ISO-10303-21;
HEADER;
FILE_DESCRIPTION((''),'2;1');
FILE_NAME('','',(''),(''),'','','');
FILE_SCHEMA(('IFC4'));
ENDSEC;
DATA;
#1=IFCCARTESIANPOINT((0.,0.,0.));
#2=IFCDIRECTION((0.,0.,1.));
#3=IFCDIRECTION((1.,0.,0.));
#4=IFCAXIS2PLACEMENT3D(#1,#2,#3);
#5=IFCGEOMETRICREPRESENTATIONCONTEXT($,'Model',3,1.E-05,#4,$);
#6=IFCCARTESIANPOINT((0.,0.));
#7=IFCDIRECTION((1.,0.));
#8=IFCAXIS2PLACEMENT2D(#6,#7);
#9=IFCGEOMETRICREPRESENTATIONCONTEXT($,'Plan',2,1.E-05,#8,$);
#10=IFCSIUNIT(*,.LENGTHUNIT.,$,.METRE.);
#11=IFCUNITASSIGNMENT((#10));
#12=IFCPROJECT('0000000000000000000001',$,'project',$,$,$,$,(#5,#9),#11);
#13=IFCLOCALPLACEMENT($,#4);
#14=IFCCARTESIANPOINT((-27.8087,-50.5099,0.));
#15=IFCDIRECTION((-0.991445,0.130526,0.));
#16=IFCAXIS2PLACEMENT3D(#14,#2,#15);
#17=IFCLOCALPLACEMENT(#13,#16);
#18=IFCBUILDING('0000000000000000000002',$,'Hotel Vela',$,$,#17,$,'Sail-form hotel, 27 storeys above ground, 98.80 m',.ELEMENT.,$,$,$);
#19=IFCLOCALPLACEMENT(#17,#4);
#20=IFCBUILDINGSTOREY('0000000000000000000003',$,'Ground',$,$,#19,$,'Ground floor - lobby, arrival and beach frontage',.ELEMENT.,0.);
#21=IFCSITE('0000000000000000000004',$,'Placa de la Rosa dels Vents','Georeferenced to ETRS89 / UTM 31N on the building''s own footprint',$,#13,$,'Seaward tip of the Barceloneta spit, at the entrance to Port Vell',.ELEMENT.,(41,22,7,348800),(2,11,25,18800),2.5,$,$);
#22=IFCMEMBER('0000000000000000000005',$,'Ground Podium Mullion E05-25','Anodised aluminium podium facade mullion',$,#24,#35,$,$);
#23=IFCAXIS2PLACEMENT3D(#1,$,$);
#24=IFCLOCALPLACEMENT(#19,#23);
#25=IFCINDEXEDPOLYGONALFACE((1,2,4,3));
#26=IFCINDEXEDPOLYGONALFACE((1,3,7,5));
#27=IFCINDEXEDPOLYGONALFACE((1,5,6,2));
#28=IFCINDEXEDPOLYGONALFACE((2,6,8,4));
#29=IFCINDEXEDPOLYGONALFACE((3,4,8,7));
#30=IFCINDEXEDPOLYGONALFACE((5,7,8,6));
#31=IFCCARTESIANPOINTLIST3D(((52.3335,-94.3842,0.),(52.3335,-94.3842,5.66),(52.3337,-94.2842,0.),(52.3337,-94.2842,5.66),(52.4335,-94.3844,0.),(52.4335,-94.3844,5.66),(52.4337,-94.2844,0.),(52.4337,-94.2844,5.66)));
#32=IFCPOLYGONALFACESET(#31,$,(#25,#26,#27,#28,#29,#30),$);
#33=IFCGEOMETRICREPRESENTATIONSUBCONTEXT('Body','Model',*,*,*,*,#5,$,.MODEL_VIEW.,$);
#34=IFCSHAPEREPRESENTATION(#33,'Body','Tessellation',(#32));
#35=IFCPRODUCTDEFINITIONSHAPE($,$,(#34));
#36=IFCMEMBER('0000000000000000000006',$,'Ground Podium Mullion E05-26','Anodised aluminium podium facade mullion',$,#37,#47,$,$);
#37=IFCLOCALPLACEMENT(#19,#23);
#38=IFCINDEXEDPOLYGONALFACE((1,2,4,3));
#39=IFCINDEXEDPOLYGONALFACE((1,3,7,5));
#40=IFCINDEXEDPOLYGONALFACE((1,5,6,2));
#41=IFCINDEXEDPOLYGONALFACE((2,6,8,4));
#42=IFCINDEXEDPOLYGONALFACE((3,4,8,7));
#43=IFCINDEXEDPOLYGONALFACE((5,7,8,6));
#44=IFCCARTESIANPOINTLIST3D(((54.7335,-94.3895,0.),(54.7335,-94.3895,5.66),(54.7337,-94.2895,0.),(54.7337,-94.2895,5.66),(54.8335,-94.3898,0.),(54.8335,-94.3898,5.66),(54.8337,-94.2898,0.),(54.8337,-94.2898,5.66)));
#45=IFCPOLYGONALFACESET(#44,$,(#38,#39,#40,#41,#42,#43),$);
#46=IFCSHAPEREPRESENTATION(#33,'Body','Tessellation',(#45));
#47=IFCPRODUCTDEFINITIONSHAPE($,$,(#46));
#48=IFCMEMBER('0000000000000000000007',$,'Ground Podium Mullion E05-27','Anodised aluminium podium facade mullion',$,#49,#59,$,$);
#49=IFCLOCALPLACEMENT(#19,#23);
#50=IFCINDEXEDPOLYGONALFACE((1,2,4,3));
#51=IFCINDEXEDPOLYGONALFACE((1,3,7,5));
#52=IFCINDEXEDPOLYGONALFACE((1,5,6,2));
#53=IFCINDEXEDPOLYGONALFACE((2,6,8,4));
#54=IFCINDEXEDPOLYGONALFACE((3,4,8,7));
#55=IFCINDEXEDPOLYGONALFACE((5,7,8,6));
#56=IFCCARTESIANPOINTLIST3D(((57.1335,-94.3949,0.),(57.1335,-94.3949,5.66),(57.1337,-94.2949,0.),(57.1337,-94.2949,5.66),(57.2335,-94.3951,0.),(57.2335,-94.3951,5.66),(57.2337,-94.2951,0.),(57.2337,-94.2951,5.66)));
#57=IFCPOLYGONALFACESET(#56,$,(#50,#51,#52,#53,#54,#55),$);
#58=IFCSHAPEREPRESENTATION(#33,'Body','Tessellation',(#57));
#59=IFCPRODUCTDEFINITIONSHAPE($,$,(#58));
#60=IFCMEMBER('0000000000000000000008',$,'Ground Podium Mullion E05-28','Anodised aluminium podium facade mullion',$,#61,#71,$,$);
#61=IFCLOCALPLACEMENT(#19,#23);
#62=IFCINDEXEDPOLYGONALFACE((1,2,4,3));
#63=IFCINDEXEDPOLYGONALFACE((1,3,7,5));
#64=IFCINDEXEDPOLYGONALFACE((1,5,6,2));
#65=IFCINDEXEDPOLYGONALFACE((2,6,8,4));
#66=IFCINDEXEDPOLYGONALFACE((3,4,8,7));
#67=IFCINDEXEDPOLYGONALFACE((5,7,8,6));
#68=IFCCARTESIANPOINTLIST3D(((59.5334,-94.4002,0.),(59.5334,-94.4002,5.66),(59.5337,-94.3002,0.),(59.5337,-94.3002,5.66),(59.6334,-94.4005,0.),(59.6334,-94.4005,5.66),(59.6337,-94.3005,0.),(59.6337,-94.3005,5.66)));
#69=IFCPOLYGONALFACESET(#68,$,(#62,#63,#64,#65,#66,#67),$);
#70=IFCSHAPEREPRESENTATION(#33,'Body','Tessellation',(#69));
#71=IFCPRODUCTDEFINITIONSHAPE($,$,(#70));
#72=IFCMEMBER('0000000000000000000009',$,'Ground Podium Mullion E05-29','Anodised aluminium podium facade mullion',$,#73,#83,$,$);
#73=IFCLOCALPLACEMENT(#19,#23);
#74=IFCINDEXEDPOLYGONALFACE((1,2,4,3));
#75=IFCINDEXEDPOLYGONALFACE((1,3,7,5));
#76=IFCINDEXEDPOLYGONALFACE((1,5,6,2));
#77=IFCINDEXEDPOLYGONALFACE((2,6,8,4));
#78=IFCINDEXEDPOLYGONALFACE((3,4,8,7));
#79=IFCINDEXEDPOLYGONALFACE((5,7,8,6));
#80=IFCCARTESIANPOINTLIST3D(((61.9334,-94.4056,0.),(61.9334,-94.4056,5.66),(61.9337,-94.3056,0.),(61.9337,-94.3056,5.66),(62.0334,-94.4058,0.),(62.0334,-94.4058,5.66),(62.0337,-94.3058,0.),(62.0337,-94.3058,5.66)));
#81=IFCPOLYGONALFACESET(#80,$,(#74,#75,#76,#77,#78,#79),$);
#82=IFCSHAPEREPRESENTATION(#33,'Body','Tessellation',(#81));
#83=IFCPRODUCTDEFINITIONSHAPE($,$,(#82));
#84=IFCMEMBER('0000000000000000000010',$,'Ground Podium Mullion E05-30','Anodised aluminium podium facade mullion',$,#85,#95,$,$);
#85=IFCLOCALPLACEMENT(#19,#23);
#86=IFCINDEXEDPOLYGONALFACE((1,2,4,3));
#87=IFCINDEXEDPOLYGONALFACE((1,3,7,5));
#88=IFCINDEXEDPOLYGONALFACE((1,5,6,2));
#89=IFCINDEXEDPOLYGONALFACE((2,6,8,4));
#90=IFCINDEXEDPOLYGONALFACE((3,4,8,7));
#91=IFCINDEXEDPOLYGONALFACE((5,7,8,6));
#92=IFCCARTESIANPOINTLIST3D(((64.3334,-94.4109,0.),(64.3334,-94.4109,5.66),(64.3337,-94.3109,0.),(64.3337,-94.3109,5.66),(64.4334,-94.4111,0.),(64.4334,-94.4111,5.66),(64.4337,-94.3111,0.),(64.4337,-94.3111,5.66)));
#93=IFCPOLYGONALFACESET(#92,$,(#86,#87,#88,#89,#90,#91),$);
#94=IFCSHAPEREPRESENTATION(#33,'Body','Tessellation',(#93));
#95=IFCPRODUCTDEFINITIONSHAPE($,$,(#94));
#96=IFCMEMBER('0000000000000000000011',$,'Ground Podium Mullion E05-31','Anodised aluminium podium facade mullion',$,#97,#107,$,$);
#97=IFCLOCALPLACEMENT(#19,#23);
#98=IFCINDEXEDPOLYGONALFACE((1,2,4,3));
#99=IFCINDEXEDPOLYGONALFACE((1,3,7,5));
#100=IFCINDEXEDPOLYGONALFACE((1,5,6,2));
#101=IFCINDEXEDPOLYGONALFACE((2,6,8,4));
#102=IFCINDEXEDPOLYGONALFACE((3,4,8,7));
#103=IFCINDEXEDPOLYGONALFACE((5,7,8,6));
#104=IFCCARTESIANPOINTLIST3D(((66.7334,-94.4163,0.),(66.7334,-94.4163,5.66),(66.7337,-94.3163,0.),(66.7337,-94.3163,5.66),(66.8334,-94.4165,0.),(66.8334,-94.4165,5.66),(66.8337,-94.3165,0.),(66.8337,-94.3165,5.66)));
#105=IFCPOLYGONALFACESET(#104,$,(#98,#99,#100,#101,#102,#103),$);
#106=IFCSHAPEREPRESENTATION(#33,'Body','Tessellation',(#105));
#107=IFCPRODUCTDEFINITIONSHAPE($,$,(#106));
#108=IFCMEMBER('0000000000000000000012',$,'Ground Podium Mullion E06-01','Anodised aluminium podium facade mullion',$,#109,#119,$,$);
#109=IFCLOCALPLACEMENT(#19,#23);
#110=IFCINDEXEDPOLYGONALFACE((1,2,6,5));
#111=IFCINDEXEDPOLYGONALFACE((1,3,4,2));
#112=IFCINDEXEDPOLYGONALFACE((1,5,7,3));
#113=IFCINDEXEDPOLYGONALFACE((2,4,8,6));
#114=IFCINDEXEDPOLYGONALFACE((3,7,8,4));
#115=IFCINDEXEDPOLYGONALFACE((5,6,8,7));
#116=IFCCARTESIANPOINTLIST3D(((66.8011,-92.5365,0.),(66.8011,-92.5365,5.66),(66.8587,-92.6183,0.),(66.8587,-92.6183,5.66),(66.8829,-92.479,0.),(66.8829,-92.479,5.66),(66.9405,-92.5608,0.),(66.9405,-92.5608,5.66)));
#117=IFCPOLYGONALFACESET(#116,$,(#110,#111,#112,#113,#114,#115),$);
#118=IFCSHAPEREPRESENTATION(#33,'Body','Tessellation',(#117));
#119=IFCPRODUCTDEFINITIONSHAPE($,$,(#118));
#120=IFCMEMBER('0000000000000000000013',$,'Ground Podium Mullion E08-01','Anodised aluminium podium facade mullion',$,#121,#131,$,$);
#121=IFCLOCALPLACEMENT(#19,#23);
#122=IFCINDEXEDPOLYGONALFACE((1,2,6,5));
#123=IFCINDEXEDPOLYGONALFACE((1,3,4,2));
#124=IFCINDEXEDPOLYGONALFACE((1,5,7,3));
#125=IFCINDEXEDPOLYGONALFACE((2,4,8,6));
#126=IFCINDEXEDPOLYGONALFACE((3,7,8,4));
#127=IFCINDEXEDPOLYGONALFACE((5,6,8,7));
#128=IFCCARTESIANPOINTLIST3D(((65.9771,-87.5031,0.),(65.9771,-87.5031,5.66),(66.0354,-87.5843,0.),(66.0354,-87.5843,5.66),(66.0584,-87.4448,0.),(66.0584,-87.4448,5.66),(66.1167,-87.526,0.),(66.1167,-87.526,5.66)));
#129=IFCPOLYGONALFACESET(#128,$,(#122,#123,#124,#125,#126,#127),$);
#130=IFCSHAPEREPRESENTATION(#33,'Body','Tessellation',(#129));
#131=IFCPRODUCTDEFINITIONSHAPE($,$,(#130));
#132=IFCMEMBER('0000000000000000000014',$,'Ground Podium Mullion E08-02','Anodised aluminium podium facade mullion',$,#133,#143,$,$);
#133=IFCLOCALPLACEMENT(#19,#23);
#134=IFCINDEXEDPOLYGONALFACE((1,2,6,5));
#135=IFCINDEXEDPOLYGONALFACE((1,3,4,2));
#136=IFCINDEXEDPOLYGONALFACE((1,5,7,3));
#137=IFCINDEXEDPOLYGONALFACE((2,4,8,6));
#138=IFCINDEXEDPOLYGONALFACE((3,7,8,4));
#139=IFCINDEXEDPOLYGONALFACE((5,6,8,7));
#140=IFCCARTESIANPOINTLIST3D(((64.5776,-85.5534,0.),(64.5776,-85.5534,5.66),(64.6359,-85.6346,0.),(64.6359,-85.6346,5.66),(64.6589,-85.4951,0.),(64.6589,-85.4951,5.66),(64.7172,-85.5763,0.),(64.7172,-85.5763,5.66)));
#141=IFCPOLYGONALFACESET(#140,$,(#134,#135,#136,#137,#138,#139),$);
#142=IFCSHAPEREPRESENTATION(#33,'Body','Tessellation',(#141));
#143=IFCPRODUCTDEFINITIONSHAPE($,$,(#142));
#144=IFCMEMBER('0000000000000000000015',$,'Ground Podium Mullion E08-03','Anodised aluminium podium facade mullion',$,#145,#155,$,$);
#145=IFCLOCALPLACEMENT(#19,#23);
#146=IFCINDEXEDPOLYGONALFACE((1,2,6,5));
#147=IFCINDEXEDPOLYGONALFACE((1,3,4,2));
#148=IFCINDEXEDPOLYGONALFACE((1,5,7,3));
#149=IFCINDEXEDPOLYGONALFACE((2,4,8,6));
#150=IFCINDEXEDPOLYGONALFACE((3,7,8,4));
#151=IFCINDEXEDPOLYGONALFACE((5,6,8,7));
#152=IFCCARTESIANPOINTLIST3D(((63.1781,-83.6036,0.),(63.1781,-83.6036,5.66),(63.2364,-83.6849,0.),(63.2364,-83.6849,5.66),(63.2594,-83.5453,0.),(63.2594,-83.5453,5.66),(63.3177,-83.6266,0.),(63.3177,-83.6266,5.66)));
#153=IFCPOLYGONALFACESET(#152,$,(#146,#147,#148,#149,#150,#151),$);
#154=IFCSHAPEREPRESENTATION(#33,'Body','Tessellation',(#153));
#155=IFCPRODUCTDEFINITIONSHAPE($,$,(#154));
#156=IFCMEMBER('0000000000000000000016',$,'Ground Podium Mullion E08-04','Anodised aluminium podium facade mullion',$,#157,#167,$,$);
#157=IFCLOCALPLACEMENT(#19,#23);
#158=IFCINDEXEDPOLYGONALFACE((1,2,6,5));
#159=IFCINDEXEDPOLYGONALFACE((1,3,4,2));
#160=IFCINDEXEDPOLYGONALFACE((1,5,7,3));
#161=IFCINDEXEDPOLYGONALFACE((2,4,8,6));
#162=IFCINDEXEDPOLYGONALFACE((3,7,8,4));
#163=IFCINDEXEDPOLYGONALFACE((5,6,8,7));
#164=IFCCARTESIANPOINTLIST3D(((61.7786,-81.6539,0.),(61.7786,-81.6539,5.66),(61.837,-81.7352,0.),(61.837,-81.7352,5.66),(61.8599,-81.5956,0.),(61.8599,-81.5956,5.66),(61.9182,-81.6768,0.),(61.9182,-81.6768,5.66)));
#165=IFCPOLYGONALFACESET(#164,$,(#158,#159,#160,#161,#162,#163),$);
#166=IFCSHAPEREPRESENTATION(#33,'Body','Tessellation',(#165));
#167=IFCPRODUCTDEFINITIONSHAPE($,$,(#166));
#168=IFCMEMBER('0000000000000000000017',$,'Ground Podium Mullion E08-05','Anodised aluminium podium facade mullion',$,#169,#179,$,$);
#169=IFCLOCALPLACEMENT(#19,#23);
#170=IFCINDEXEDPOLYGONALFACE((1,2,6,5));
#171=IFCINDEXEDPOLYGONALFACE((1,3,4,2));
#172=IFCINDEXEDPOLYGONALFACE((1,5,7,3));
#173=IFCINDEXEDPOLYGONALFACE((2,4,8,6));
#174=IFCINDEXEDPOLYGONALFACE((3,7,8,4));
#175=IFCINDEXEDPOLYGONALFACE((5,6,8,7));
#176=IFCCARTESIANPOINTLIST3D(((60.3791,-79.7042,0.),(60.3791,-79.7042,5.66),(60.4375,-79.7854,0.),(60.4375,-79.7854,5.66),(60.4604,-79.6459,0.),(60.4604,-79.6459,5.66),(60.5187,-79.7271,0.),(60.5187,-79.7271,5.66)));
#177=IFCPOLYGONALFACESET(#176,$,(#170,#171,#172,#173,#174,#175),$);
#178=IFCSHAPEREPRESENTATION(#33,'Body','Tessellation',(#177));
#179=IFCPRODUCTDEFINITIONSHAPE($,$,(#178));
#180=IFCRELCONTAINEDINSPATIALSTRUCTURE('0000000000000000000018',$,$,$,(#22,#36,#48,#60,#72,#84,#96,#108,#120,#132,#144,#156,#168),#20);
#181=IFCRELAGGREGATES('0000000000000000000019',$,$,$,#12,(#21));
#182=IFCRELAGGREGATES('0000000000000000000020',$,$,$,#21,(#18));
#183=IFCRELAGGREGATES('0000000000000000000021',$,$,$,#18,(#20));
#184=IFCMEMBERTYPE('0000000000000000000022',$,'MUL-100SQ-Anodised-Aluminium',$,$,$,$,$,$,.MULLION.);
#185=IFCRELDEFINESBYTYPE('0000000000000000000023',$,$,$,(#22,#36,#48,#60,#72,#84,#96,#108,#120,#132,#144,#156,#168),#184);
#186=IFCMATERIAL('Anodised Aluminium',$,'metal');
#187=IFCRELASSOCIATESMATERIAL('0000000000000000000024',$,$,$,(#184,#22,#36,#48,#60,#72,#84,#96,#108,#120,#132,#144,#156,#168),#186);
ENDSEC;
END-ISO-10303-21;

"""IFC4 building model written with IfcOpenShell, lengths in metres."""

from ifc_helpers import new_model, si_unit, frame, origin_with_axes, origin_2d_with_axis, place, context, subcontext, project, spatial, line, indexed_curve, rectangle, outline, extrude, material, material_profile, profile_set, profile_usage, type_object, element, save


model = new_model("IFC4")

# Units and contexts
model_context = context("Model", 3, precision=1e-05, world=origin_with_axes())
plan_context = context("Plan", 2, precision=1e-05, world=origin_2d_with_axis())
body_context = subcontext(model_context, "Body", "Model", "MODEL_VIEW")
ifc_project = project(units=[si_unit("LENGTHUNIT", "METRE")], contexts=[model_context, plan_context])

# Site, building, storey
site_placement = place(None, origin_with_axes())
site = spatial("IfcSite", under=ifc_project, at=site_placement, Name="Placa de la Rosa dels Vents", Description="Georeferenced to ETRS89 / UTM 31N on the building's own footprint", LongName="Seaward tip of the Barceloneta spit, at the entrance to Port Vell", CompositionType="ELEMENT", RefLatitude=(41, 22, 7, 348800), RefLongitude=(2, 11, 25, 18800), RefElevation=2.5)
building_placement = place(site_placement, frame((-27.8087, -50.5099, 0.0), z_axis=(0.0, 0.0, 1.0), x_axis=(-0.991445, 0.130526, 0.0)))
building = spatial("IfcBuilding", under=site, at=building_placement, Name="Hotel Vela", LongName="Sail-form hotel, 27 storeys above ground, 98.80 m", CompositionType="ELEMENT")
storey_placement = place(building_placement, origin_with_axes())
storey = spatial("IfcBuildingStorey", under=building, at=storey_placement, Name="Ground", LongName="Ground floor - lobby, arrival and beach frontage", CompositionType="ELEMENT", Elevation=0.0)

# Members
ifc_material_1 = material(Name="Anodised Aluminium", Category="metal")
ifc_material_profile = material_profile(ifc_material_1, rectangle(XDim=0.1, YDim=0.1))
ifc_profile_set = profile_set([ifc_material_profile], Name="MUL-100SQ-Anodised-Aluminium")
ifc_profile_usage_1 = profile_usage(ifc_profile_set)
member_type = type_object("IfcMemberType", Name="MUL-100SQ-Anodised-Aluminium", PredefinedType="MULLION", material=ifc_profile_set)
member_1_placement = place(storey_placement, frame((52.3335, -94.3842, 0.0), z_axis=(0.0, 0.0, 1.0), x_axis=(0.999998, -0.002226, 0.0)))
element("IfcMember", 1, at=member_1_placement, inside=storey, type_object=member_type, material=ifc_profile_usage_1, Name="Ground Podium Mullion E05-25", Description="Anodised aluminium podium facade mullion", context=body_context, shape_type="SweptSolid", body=[
    extrude(outline(indexed_curve([(0.0, 0.0), (0.1, 0.0), (0.1, 0.1), (0.0, 0.1)], segments=[line(1, 2, 3, 4, 1)])), origin_with_axes(), (0.0, 0.0, 1.0), 5.66),
])
ifc_profile_usage_2 = profile_usage(ifc_profile_set)
member_2_placement = place(storey_placement, frame((54.7335, -94.3895, 0.0), z_axis=(0.0, 0.0, 1.0), x_axis=(0.999998, -0.002226, 0.0)))
element("IfcMember", 2, at=member_2_placement, inside=storey, type_object=member_type, material=ifc_profile_usage_2, Name="Ground Podium Mullion E05-26", Description="Anodised aluminium podium facade mullion", context=body_context, shape_type="SweptSolid", body=[
    extrude(outline(indexed_curve([(0.0, 0.0), (0.1, 0.0), (0.1, 0.1), (0.0, 0.1)], segments=[line(1, 2, 3, 4, 1)])), origin_with_axes(), (0.0, 0.0, 1.0), 5.66),
])
ifc_profile_usage_3 = profile_usage(ifc_profile_set)
member_3_placement = place(storey_placement, frame((57.1335, -94.3949, 0.0), z_axis=(0.0, 0.0, 1.0), x_axis=(0.999998, -0.002226, 0.0)))
element("IfcMember", 3, at=member_3_placement, inside=storey, type_object=member_type, material=ifc_profile_usage_3, Name="Ground Podium Mullion E05-27", Description="Anodised aluminium podium facade mullion", context=body_context, shape_type="SweptSolid", body=[
    extrude(outline(indexed_curve([(0.0, 0.0), (0.1, 0.0), (0.1, 0.1), (0.0, 0.1)], segments=[line(1, 2, 3, 4, 1)])), origin_with_axes(), (0.0, 0.0, 1.0), 5.66),
])
ifc_profile_usage_4 = profile_usage(ifc_profile_set)
member_4_placement = place(storey_placement, frame((59.5334, -94.4002, 0.0), z_axis=(0.0, 0.0, 1.0), x_axis=(0.999998, -0.002226, 0.0)))
element("IfcMember", 4, at=member_4_placement, inside=storey, type_object=member_type, material=ifc_profile_usage_4, Name="Ground Podium Mullion E05-28", Description="Anodised aluminium podium facade mullion", context=body_context, shape_type="SweptSolid", body=[
    extrude(outline(indexed_curve([(0.0, 0.0), (0.1, 0.0), (0.1, 0.1), (0.0, 0.1)], segments=[line(1, 2, 3, 4, 1)])), origin_with_axes(), (0.0, 0.0, 1.0), 5.66),
])
ifc_profile_usage_5 = profile_usage(ifc_profile_set)
member_5_placement = place(storey_placement, frame((61.9334, -94.4056, 0.0), z_axis=(0.0, 0.0, 1.0), x_axis=(0.999998, -0.002226, 0.0)))
element("IfcMember", 5, at=member_5_placement, inside=storey, type_object=member_type, material=ifc_profile_usage_5, Name="Ground Podium Mullion E05-29", Description="Anodised aluminium podium facade mullion", context=body_context, shape_type="SweptSolid", body=[
    extrude(outline(indexed_curve([(0.0, 0.0), (0.1, 0.0), (0.1, 0.1), (0.0, 0.1)], segments=[line(1, 2, 3, 4, 1)])), origin_with_axes(), (0.0, 0.0, 1.0), 5.66),
])
ifc_profile_usage_6 = profile_usage(ifc_profile_set)
member_6_placement = place(storey_placement, frame((64.3334, -94.4109, 0.0), z_axis=(0.0, 0.0, 1.0), x_axis=(0.999998, -0.002226, 0.0)))
element("IfcMember", 6, at=member_6_placement, inside=storey, type_object=member_type, material=ifc_profile_usage_6, Name="Ground Podium Mullion E05-30", Description="Anodised aluminium podium facade mullion", context=body_context, shape_type="SweptSolid", body=[
    extrude(outline(indexed_curve([(0.0, 0.0), (0.1, 0.0), (0.1, 0.1), (0.0, 0.1)], segments=[line(1, 2, 3, 4, 1)])), origin_with_axes(), (0.0, 0.0, 1.0), 5.66),
])
ifc_profile_usage_7 = profile_usage(ifc_profile_set)
member_7_placement = place(storey_placement, frame((66.7334, -94.4163, 0.0), z_axis=(0.0, 0.0, 1.0), x_axis=(0.999998, -0.002226, 0.0)))
element("IfcMember", 7, at=member_7_placement, inside=storey, type_object=member_type, material=ifc_profile_usage_7, Name="Ground Podium Mullion E05-31", Description="Anodised aluminium podium facade mullion", context=body_context, shape_type="SweptSolid", body=[
    extrude(outline(indexed_curve([(0.0, 0.0), (0.1, 0.0), (0.1, 0.1), (0.0, 0.1)], segments=[line(1, 2, 3, 4, 1)])), origin_with_axes(), (0.0, 0.0, 1.0), 5.66),
])
ifc_profile_usage_8 = profile_usage(ifc_profile_set)
member_8_placement = place(storey_placement, frame((66.9405, -92.5608, 0.0), z_axis=(0.0, 0.0, 1.0), x_axis=(-0.575361, 0.817899, 0.0)))
element("IfcMember", 8, at=member_8_placement, inside=storey, type_object=member_type, material=ifc_profile_usage_8, Name="Ground Podium Mullion E06-01", Description="Anodised aluminium podium facade mullion", context=body_context, shape_type="SweptSolid", body=[
    extrude(outline(indexed_curve([(0.0, 0.0), (0.1, 0.0), (0.1, 0.1), (0.0, 0.1)], segments=[line(1, 2, 3, 4, 1)])), origin_with_axes(), (0.0, 0.0, 1.0), 5.66),
])
ifc_profile_usage_9 = profile_usage(ifc_profile_set)
member_9_placement = place(storey_placement, frame((66.1167, -87.526, 0.0), z_axis=(0.0, 0.0, 1.0), x_axis=(-0.583121, 0.812385, 0.0)))
element("IfcMember", 9, at=member_9_placement, inside=storey, type_object=member_type, material=ifc_profile_usage_9, Name="Ground Podium Mullion E08-01", Description="Anodised aluminium podium facade mullion", context=body_context, shape_type="SweptSolid", body=[
    extrude(outline(indexed_curve([(0.0, 0.0), (0.1, 0.0), (0.1, 0.1), (0.0, 0.1)], segments=[line(1, 2, 3, 4, 1)])), origin_with_axes(), (0.0, 0.0, 1.0), 5.66),
])
ifc_profile_usage_10 = profile_usage(ifc_profile_set)
member_10_placement = place(storey_placement, frame((64.7172, -85.5763, 0.0), z_axis=(0.0, 0.0, 1.0), x_axis=(-0.583121, 0.812385, 0.0)))
element("IfcMember", 10, at=member_10_placement, inside=storey, type_object=member_type, material=ifc_profile_usage_10, Name="Ground Podium Mullion E08-02", Description="Anodised aluminium podium facade mullion", context=body_context, shape_type="SweptSolid", body=[
    extrude(outline(indexed_curve([(0.0, 0.0), (0.1, 0.0), (0.1, 0.1), (0.0, 0.1)], segments=[line(1, 2, 3, 4, 1)])), origin_with_axes(), (0.0, 0.0, 1.0), 5.66),
])
ifc_profile_usage_11 = profile_usage(ifc_profile_set)
member_11_placement = place(storey_placement, frame((63.3177, -83.6266, 0.0), z_axis=(0.0, 0.0, 1.0), x_axis=(-0.583121, 0.812385, 0.0)))
element("IfcMember", 11, at=member_11_placement, inside=storey, type_object=member_type, material=ifc_profile_usage_11, Name="Ground Podium Mullion E08-03", Description="Anodised aluminium podium facade mullion", context=body_context, shape_type="SweptSolid", body=[
    extrude(outline(indexed_curve([(0.0, 0.0), (0.1, 0.0), (0.1, 0.1), (0.0, 0.1)], segments=[line(1, 2, 3, 4, 1)])), origin_with_axes(), (0.0, 0.0, 1.0), 5.66),
])
ifc_profile_usage_12 = profile_usage(ifc_profile_set)
member_12_placement = place(storey_placement, frame((61.9182, -81.6768, 0.0), z_axis=(0.0, 0.0, 1.0), x_axis=(-0.583121, 0.812385, 0.0)))
element("IfcMember", 12, at=member_12_placement, inside=storey, type_object=member_type, material=ifc_profile_usage_12, Name="Ground Podium Mullion E08-04", Description="Anodised aluminium podium facade mullion", context=body_context, shape_type="SweptSolid", body=[
    extrude(outline(indexed_curve([(0.0, 0.0), (0.1, 0.0), (0.1, 0.1), (0.0, 0.1)], segments=[line(1, 2, 3, 4, 1)])), origin_with_axes(), (0.0, 0.0, 1.0), 5.66),
])
ifc_profile_usage_13 = profile_usage(ifc_profile_set)
member_13_placement = place(storey_placement, frame((60.5187, -79.7271, 0.0), z_axis=(0.0, 0.0, 1.0), x_axis=(-0.583121, 0.812385, 0.0)))
element("IfcMember", 13, at=member_13_placement, inside=storey, type_object=member_type, material=ifc_profile_usage_13, Name="Ground Podium Mullion E08-05", Description="Anodised aluminium podium facade mullion", context=body_context, shape_type="SweptSolid", body=[
    extrude(outline(indexed_curve([(0.0, 0.0), (0.1, 0.0), (0.1, 0.1), (0.0, 0.1)], segments=[line(1, 2, 3, 4, 1)])), origin_with_axes(), (0.0, 0.0, 1.0), 5.66),
])

save(model, "model.ifc")
